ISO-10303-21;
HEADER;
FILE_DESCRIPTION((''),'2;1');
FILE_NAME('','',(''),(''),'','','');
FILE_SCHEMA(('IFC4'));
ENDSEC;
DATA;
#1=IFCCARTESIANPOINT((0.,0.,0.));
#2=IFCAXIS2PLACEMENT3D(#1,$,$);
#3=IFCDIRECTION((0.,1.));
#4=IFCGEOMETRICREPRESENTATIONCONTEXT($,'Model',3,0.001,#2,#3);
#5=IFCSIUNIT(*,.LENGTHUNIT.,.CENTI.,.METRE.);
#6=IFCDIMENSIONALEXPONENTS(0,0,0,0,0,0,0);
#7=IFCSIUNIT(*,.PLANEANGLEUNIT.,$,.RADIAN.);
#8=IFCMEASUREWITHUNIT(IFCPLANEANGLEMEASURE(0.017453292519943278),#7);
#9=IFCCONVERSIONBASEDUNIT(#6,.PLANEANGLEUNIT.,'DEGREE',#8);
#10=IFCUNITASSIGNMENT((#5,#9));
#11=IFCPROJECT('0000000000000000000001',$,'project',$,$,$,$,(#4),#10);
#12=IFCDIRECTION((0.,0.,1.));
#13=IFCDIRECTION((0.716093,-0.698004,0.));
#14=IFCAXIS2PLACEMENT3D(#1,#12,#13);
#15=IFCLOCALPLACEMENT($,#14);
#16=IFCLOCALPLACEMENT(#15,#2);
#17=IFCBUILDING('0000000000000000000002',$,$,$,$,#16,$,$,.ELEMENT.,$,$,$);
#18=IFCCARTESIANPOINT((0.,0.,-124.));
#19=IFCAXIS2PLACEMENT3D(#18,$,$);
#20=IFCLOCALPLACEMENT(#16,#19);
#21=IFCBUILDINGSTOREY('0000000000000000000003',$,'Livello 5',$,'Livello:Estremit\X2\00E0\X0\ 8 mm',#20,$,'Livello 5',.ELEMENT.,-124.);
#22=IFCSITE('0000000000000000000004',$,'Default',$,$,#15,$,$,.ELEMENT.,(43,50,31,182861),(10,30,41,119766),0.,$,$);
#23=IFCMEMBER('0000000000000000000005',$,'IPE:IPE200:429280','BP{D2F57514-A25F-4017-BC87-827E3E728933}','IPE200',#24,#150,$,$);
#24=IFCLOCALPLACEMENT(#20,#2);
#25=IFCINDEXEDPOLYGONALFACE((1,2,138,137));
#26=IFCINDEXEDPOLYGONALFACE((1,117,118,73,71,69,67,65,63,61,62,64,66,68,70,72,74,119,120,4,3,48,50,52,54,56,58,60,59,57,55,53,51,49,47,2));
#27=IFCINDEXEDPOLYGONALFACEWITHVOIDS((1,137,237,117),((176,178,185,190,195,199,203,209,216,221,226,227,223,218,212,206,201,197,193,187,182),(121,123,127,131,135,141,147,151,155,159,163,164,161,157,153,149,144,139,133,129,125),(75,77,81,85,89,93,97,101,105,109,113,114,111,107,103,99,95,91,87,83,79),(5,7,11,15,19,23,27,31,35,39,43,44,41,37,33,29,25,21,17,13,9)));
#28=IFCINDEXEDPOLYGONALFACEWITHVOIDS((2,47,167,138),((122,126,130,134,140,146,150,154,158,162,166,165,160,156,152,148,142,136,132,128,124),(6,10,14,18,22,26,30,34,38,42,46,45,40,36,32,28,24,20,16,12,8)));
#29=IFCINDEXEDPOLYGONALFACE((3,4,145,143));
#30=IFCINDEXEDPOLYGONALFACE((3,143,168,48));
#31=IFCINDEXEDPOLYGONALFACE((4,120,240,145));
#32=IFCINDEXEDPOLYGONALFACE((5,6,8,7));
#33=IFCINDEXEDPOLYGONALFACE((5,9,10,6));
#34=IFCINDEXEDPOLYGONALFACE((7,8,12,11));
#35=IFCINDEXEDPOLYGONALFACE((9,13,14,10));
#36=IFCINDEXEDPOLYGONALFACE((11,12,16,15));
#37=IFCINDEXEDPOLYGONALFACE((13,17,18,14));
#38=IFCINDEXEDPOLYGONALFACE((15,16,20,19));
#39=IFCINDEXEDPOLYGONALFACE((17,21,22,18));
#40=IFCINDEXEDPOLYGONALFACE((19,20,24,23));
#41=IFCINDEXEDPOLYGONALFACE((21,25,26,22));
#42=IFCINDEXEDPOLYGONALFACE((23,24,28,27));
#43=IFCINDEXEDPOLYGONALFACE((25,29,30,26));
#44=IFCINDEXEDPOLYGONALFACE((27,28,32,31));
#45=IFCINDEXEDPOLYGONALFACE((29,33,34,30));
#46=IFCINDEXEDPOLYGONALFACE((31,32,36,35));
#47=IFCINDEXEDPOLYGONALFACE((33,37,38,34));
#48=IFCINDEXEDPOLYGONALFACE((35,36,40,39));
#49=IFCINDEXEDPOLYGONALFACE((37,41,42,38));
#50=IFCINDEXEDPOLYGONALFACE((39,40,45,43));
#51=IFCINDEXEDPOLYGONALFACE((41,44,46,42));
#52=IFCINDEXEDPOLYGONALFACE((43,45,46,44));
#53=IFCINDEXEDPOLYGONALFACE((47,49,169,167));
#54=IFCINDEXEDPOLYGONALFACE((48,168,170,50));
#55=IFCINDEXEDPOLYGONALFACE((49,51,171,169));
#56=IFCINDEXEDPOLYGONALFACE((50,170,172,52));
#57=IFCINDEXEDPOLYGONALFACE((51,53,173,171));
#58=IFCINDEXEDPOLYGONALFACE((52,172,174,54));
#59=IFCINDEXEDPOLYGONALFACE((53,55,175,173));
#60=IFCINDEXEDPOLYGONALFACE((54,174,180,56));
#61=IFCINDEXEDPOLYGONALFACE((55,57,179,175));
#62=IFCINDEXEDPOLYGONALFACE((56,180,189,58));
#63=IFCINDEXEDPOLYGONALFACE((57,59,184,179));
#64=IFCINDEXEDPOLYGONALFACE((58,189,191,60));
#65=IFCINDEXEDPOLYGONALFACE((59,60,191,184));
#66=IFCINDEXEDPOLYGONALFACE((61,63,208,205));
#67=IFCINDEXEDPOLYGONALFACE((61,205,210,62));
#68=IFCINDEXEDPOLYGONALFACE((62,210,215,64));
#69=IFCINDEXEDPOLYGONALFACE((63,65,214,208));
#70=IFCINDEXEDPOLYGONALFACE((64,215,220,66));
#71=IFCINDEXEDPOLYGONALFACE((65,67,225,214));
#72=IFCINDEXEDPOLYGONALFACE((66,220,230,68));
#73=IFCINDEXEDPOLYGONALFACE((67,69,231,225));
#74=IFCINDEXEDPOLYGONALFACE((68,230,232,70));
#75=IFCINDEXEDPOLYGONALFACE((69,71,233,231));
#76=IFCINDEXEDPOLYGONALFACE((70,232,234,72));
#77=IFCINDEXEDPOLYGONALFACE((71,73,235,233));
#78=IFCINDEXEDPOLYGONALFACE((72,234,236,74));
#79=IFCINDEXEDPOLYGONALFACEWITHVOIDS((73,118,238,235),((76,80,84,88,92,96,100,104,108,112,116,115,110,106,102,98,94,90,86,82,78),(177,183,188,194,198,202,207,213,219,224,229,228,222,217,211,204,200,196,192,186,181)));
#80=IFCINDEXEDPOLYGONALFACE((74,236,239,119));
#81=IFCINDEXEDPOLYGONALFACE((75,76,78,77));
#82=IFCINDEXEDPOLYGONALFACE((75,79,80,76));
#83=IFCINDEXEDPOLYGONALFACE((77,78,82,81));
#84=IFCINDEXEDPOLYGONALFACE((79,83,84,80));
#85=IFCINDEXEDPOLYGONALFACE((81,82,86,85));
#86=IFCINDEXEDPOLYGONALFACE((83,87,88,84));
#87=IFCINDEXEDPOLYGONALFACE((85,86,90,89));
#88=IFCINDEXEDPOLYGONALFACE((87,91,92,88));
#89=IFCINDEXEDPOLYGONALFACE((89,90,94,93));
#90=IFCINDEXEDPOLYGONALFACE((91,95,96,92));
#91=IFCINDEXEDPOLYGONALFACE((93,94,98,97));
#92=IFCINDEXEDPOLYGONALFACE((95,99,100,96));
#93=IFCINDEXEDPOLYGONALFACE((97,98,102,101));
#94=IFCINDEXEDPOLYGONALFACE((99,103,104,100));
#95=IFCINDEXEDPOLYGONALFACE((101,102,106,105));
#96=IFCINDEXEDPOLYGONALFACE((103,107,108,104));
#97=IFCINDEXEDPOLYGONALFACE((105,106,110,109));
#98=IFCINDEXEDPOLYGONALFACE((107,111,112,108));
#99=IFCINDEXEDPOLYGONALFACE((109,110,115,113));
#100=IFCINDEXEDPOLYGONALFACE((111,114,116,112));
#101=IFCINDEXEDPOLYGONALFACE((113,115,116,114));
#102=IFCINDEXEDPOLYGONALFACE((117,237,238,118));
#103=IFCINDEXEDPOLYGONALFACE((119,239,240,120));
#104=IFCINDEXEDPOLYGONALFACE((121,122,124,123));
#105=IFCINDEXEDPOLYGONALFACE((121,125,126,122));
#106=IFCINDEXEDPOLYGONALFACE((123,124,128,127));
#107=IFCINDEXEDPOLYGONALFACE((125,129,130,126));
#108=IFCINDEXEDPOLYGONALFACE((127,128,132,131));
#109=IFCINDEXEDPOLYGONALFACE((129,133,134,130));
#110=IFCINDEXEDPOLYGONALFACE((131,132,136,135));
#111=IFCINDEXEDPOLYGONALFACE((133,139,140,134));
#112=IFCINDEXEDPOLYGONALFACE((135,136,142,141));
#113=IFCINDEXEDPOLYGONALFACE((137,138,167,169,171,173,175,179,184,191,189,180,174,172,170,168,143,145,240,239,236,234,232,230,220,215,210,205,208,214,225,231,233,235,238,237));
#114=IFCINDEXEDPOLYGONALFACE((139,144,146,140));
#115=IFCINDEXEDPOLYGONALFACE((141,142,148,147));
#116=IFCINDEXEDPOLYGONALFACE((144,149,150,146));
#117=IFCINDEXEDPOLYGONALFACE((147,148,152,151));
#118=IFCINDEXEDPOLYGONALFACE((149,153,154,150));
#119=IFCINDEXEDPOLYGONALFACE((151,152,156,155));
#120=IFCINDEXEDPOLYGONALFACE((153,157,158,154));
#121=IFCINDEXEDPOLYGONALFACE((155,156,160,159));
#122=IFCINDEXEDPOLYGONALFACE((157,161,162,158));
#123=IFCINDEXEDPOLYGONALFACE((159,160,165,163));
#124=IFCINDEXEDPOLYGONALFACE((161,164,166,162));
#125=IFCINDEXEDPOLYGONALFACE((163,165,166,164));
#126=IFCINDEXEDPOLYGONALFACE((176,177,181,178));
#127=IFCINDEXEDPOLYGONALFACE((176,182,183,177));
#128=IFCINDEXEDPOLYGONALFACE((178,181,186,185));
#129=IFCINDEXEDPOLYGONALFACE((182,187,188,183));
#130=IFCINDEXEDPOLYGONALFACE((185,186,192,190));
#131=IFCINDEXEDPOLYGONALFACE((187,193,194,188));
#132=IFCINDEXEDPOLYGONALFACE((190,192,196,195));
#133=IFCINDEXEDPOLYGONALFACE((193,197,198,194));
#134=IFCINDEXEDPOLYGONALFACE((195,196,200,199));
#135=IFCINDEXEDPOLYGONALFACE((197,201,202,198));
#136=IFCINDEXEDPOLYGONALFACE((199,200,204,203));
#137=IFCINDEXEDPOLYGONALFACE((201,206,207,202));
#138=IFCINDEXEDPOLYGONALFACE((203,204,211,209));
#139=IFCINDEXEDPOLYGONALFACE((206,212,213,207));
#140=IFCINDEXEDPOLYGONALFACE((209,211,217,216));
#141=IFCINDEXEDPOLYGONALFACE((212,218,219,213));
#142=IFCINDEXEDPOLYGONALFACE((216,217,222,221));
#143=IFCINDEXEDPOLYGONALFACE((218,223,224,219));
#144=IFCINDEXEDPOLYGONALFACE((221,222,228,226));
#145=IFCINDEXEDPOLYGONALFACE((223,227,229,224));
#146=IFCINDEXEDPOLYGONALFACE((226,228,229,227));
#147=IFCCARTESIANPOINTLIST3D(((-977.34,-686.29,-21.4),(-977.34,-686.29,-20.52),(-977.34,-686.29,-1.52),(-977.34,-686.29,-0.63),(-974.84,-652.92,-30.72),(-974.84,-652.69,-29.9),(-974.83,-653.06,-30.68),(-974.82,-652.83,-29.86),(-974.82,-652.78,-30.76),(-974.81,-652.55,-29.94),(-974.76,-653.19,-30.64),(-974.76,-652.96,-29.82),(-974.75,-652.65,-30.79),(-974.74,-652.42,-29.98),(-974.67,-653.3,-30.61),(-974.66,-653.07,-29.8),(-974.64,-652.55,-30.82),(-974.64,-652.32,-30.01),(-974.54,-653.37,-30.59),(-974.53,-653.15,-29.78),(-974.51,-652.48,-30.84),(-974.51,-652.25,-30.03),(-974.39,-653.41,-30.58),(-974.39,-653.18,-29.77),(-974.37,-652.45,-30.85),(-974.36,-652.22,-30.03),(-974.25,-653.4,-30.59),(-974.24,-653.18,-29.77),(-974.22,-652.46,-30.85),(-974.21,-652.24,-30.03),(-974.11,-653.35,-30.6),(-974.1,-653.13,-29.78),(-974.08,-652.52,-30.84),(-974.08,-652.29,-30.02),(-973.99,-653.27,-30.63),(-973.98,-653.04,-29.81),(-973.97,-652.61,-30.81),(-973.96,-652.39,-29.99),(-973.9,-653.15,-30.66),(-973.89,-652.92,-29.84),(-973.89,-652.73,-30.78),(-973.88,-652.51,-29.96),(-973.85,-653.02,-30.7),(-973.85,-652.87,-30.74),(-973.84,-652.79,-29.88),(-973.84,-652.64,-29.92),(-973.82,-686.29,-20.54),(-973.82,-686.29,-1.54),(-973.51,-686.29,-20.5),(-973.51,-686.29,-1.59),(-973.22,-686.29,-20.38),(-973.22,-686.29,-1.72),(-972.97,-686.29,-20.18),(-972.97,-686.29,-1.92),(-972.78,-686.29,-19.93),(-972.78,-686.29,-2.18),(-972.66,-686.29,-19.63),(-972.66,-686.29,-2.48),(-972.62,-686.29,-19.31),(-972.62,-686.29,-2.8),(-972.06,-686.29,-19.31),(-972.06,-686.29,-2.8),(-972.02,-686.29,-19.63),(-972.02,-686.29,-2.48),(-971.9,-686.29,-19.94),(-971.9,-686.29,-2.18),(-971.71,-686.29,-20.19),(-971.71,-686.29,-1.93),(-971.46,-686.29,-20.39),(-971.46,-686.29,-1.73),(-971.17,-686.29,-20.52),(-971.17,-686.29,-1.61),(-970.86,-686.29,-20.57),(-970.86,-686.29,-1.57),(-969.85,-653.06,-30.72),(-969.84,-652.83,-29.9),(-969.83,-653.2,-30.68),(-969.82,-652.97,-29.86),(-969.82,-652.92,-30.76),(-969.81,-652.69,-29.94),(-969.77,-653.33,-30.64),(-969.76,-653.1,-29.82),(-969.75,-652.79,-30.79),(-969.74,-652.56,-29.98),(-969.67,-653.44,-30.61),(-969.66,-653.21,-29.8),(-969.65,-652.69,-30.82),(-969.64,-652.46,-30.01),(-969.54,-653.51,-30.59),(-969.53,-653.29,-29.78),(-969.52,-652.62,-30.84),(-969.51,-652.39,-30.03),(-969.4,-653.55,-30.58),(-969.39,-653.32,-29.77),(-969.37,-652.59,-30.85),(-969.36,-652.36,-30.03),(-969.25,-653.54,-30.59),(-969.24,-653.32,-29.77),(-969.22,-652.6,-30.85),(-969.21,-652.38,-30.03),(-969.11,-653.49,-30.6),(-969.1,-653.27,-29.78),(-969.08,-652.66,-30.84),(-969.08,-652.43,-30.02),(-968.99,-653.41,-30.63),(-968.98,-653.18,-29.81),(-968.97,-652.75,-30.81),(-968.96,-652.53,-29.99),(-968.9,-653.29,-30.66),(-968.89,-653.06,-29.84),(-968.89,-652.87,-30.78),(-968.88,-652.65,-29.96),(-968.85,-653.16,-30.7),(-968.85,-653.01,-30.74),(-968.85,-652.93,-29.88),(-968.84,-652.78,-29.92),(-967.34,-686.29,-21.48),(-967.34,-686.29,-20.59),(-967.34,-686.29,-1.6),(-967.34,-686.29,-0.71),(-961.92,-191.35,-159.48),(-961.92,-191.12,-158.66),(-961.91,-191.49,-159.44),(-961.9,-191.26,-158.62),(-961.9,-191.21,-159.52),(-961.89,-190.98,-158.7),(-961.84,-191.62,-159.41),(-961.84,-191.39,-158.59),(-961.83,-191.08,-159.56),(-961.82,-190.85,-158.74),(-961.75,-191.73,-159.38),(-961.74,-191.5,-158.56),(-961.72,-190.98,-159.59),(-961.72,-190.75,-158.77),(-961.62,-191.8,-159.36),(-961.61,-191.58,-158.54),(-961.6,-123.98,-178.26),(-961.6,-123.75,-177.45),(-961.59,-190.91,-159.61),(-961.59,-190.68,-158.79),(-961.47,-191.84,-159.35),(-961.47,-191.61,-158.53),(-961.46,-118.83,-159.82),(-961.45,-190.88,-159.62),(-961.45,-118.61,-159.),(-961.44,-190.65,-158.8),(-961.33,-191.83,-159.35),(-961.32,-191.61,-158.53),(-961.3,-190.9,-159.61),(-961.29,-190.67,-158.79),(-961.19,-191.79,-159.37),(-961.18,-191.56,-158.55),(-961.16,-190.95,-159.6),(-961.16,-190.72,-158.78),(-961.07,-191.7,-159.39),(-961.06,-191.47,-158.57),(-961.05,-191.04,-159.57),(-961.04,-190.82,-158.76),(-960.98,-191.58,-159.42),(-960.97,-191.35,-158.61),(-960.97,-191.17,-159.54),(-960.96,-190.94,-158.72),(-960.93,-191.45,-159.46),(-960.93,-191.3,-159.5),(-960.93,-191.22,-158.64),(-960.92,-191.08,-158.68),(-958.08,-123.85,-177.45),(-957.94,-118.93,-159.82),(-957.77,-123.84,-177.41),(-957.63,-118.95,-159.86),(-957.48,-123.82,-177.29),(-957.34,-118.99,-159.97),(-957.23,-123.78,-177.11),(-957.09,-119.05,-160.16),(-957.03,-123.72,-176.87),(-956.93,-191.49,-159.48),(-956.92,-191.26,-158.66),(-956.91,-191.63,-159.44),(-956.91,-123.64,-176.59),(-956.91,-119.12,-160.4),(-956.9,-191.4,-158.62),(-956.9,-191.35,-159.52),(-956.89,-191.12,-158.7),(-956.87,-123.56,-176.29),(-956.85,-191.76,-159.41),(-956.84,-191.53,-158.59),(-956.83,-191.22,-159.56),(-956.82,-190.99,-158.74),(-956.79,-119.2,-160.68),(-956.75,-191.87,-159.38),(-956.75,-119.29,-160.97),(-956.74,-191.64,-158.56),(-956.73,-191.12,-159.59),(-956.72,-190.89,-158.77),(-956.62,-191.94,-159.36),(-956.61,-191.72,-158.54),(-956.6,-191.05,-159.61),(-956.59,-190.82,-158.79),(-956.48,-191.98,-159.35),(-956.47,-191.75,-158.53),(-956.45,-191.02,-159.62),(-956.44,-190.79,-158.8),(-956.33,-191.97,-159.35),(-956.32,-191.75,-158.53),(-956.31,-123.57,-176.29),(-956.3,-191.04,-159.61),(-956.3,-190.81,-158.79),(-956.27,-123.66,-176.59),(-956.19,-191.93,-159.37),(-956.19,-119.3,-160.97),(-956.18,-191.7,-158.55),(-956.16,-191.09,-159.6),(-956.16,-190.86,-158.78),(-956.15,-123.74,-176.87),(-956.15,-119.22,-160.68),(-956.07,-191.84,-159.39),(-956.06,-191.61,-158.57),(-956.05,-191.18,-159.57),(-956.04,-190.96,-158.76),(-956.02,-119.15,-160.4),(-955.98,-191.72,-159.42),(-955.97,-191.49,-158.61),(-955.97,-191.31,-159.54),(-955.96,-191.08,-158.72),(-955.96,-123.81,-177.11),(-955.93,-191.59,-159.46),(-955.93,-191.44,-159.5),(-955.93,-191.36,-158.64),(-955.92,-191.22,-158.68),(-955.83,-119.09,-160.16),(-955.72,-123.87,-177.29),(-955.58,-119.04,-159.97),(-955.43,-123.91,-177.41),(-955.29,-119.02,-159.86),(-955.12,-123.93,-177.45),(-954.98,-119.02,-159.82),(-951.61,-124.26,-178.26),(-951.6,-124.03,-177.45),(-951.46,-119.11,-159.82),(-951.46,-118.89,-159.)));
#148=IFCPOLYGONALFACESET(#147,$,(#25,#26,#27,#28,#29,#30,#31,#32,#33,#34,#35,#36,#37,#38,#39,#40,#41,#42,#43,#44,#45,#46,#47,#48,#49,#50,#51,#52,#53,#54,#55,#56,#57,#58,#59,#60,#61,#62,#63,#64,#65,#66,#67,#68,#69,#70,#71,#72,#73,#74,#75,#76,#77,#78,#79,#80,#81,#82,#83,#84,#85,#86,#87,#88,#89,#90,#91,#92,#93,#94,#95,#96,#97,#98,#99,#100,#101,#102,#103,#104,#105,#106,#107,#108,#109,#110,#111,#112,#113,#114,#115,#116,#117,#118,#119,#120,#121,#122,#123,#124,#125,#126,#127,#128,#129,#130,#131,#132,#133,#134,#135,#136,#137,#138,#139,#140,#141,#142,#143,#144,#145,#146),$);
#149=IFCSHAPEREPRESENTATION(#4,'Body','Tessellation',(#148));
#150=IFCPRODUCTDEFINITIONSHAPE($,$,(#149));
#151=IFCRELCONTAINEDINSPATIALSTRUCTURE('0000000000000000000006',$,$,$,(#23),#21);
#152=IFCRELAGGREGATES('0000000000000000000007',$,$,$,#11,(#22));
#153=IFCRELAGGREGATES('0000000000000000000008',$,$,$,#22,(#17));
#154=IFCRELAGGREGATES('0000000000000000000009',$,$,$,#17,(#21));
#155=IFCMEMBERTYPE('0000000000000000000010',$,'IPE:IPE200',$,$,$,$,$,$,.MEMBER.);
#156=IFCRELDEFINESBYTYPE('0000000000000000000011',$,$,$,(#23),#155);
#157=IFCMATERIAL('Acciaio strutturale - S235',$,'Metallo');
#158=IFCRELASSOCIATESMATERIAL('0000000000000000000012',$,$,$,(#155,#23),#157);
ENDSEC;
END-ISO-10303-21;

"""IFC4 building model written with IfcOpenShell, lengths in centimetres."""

from ifc_helpers import new_model, entity, si_unit, converted_unit, direction, frame, frame_2d, origin, origin_2d, place, context, project, spatial, circle, i_section, extrude, clip, halfspace, material, type_object, element, save


model = new_model("IFC4")

# Units and contexts
model_context = context("Model", 3, precision=0.001, world=origin(), true_north=direction((0.0, 1.0)))
ifc_project = project(units=[si_unit("LENGTHUNIT", "METRE", prefix="CENTI"), converted_unit("PLANEANGLEUNIT", "DEGREE", entity("IfcPlaneAngleMeasure", 0.017453292519943278), si_unit("PLANEANGLEUNIT", "RADIAN"), dimensions=[0, 0, 0, 0, 0, 0, 0])], contexts=[model_context])

# Site, building, storey
site_placement = place(None, frame((0.0, 0.0, 0.0), z_axis=(0.0, 0.0, 1.0), x_axis=(0.716093, -0.698004, 0.0)))
site = spatial("IfcSite", under=ifc_project, at=site_placement, Name="Default", CompositionType="ELEMENT", RefLatitude=(43, 50, 31, 182861), RefLongitude=(10, 30, 41, 119766), RefElevation=0.0)
building_placement = place(site_placement, origin())
building = spatial("IfcBuilding", under=site, at=building_placement, CompositionType="ELEMENT")
storey_placement = place(building_placement, frame((0.0, 0.0, -124.0)))
storey = spatial("IfcBuildingStorey", under=building, at=storey_placement, Name="Livello 5", ObjectType="Livello:Estremità 8 mm", LongName="Livello 5", CompositionType="ELEMENT", Elevation=-124.0)

# Shared definitions
ifc_material_1 = material(Name="Acciaio strutturale - S235", Category="Metallo")

# Member, openings
member_type_1 = type_object("IfcMemberType", Name="IPE:IPE200", PredefinedType="MEMBER", material=ifc_material_1)
member_1_placement = place(storey_placement, frame((-973.46, -726.15, 0.07), z_axis=(-0.026952, -0.962871, 0.268612), x_axis=(0.999608, -0.02798, 0.0)))
member_1 = element("IfcMember", 1, at=member_1_placement, inside=storey, type_object=member_type_1, material=ifc_material_1, Name="IPE:IPE200:429280", Description="BP{D2F57514-A25F-4017-BC87-827E3E728933}", ObjectType="IPE200", context=model_context, shape_type="Clipping", body=[
    clip(extrude(i_section(OverallWidth=10.0, OverallDepth=20.0, WebThickness=0.56, FlangeThickness=0.85, FilletRadius=1.2, at=origin_2d()), origin(), (0.0, 0.0, -1.0), 628.04), halfspace(frame((971.96, 137.4, -31.33), z_axis=(-0.02798, 0.268507, -0.962871), x_axis=(-0.999608, -0.007516, 0.026952)), True)),
])
opening_1_placement = place(member_1_placement, frame((1.56, -9.1, -558.11), z_axis=(0.0, 1.0, 0.0), x_axis=(-1.0, 0.0, 0.0)))
element("IfcOpeningElement", 2, at=opening_1_placement, cuts=member_1, ObjectType="Opening", context=model_context, shape_type="SweptSolid", body=[
    extrude(circle(Radius=0.5, at=frame_2d((-0.5, 0.0), x_axis=(1.0, 0.0))), origin(), (0.0, 0.0, -1.0), 0.95),
])
opening_2_placement = place(member_1_placement, frame((-3.44, -9.1, -558.11), z_axis=(0.0, 1.0, 0.0), x_axis=(-1.0, 0.0, 0.0)))
element("IfcOpeningElement", 3, at=opening_2_placement, cuts=member_1, ObjectType="Opening", context=model_context, shape_type="SweptSolid", body=[
    extrude(circle(Radius=0.5, at=frame_2d((-0.5, 0.0), x_axis=(1.0, 0.0))), origin(), (0.0, 0.0, -1.0), 0.95),
])
opening_3_placement = place(member_1_placement, frame((1.56, -9.1, -78.75), z_axis=(0.0, 1.0, 0.0), x_axis=(-1.0, 0.0, 0.0)))
element("IfcOpeningElement", 4, at=opening_3_placement, cuts=member_1, ObjectType="Opening", context=model_context, shape_type="SweptSolid", body=[
    extrude(circle(Radius=0.5, at=frame_2d((-0.5, 0.0), x_axis=(1.0, 0.0))), origin(), (0.0, 0.0, -1.0), 0.95),
])
opening_4_placement = place(member_1_placement, frame((-3.44, -9.1, -78.75), z_axis=(0.0, 1.0, 0.0), x_axis=(-1.0, 0.0, 0.0)))
element("IfcOpeningElement", 5, at=opening_4_placement, cuts=member_1, ObjectType="Opening", context=model_context, shape_type="SweptSolid", body=[
    extrude(circle(Radius=0.5, at=frame_2d((-0.5, 0.0), x_axis=(1.0, 0.0))), origin(), (0.0, 0.0, -1.0), 0.95),
])

save(model, "model.ifc")
